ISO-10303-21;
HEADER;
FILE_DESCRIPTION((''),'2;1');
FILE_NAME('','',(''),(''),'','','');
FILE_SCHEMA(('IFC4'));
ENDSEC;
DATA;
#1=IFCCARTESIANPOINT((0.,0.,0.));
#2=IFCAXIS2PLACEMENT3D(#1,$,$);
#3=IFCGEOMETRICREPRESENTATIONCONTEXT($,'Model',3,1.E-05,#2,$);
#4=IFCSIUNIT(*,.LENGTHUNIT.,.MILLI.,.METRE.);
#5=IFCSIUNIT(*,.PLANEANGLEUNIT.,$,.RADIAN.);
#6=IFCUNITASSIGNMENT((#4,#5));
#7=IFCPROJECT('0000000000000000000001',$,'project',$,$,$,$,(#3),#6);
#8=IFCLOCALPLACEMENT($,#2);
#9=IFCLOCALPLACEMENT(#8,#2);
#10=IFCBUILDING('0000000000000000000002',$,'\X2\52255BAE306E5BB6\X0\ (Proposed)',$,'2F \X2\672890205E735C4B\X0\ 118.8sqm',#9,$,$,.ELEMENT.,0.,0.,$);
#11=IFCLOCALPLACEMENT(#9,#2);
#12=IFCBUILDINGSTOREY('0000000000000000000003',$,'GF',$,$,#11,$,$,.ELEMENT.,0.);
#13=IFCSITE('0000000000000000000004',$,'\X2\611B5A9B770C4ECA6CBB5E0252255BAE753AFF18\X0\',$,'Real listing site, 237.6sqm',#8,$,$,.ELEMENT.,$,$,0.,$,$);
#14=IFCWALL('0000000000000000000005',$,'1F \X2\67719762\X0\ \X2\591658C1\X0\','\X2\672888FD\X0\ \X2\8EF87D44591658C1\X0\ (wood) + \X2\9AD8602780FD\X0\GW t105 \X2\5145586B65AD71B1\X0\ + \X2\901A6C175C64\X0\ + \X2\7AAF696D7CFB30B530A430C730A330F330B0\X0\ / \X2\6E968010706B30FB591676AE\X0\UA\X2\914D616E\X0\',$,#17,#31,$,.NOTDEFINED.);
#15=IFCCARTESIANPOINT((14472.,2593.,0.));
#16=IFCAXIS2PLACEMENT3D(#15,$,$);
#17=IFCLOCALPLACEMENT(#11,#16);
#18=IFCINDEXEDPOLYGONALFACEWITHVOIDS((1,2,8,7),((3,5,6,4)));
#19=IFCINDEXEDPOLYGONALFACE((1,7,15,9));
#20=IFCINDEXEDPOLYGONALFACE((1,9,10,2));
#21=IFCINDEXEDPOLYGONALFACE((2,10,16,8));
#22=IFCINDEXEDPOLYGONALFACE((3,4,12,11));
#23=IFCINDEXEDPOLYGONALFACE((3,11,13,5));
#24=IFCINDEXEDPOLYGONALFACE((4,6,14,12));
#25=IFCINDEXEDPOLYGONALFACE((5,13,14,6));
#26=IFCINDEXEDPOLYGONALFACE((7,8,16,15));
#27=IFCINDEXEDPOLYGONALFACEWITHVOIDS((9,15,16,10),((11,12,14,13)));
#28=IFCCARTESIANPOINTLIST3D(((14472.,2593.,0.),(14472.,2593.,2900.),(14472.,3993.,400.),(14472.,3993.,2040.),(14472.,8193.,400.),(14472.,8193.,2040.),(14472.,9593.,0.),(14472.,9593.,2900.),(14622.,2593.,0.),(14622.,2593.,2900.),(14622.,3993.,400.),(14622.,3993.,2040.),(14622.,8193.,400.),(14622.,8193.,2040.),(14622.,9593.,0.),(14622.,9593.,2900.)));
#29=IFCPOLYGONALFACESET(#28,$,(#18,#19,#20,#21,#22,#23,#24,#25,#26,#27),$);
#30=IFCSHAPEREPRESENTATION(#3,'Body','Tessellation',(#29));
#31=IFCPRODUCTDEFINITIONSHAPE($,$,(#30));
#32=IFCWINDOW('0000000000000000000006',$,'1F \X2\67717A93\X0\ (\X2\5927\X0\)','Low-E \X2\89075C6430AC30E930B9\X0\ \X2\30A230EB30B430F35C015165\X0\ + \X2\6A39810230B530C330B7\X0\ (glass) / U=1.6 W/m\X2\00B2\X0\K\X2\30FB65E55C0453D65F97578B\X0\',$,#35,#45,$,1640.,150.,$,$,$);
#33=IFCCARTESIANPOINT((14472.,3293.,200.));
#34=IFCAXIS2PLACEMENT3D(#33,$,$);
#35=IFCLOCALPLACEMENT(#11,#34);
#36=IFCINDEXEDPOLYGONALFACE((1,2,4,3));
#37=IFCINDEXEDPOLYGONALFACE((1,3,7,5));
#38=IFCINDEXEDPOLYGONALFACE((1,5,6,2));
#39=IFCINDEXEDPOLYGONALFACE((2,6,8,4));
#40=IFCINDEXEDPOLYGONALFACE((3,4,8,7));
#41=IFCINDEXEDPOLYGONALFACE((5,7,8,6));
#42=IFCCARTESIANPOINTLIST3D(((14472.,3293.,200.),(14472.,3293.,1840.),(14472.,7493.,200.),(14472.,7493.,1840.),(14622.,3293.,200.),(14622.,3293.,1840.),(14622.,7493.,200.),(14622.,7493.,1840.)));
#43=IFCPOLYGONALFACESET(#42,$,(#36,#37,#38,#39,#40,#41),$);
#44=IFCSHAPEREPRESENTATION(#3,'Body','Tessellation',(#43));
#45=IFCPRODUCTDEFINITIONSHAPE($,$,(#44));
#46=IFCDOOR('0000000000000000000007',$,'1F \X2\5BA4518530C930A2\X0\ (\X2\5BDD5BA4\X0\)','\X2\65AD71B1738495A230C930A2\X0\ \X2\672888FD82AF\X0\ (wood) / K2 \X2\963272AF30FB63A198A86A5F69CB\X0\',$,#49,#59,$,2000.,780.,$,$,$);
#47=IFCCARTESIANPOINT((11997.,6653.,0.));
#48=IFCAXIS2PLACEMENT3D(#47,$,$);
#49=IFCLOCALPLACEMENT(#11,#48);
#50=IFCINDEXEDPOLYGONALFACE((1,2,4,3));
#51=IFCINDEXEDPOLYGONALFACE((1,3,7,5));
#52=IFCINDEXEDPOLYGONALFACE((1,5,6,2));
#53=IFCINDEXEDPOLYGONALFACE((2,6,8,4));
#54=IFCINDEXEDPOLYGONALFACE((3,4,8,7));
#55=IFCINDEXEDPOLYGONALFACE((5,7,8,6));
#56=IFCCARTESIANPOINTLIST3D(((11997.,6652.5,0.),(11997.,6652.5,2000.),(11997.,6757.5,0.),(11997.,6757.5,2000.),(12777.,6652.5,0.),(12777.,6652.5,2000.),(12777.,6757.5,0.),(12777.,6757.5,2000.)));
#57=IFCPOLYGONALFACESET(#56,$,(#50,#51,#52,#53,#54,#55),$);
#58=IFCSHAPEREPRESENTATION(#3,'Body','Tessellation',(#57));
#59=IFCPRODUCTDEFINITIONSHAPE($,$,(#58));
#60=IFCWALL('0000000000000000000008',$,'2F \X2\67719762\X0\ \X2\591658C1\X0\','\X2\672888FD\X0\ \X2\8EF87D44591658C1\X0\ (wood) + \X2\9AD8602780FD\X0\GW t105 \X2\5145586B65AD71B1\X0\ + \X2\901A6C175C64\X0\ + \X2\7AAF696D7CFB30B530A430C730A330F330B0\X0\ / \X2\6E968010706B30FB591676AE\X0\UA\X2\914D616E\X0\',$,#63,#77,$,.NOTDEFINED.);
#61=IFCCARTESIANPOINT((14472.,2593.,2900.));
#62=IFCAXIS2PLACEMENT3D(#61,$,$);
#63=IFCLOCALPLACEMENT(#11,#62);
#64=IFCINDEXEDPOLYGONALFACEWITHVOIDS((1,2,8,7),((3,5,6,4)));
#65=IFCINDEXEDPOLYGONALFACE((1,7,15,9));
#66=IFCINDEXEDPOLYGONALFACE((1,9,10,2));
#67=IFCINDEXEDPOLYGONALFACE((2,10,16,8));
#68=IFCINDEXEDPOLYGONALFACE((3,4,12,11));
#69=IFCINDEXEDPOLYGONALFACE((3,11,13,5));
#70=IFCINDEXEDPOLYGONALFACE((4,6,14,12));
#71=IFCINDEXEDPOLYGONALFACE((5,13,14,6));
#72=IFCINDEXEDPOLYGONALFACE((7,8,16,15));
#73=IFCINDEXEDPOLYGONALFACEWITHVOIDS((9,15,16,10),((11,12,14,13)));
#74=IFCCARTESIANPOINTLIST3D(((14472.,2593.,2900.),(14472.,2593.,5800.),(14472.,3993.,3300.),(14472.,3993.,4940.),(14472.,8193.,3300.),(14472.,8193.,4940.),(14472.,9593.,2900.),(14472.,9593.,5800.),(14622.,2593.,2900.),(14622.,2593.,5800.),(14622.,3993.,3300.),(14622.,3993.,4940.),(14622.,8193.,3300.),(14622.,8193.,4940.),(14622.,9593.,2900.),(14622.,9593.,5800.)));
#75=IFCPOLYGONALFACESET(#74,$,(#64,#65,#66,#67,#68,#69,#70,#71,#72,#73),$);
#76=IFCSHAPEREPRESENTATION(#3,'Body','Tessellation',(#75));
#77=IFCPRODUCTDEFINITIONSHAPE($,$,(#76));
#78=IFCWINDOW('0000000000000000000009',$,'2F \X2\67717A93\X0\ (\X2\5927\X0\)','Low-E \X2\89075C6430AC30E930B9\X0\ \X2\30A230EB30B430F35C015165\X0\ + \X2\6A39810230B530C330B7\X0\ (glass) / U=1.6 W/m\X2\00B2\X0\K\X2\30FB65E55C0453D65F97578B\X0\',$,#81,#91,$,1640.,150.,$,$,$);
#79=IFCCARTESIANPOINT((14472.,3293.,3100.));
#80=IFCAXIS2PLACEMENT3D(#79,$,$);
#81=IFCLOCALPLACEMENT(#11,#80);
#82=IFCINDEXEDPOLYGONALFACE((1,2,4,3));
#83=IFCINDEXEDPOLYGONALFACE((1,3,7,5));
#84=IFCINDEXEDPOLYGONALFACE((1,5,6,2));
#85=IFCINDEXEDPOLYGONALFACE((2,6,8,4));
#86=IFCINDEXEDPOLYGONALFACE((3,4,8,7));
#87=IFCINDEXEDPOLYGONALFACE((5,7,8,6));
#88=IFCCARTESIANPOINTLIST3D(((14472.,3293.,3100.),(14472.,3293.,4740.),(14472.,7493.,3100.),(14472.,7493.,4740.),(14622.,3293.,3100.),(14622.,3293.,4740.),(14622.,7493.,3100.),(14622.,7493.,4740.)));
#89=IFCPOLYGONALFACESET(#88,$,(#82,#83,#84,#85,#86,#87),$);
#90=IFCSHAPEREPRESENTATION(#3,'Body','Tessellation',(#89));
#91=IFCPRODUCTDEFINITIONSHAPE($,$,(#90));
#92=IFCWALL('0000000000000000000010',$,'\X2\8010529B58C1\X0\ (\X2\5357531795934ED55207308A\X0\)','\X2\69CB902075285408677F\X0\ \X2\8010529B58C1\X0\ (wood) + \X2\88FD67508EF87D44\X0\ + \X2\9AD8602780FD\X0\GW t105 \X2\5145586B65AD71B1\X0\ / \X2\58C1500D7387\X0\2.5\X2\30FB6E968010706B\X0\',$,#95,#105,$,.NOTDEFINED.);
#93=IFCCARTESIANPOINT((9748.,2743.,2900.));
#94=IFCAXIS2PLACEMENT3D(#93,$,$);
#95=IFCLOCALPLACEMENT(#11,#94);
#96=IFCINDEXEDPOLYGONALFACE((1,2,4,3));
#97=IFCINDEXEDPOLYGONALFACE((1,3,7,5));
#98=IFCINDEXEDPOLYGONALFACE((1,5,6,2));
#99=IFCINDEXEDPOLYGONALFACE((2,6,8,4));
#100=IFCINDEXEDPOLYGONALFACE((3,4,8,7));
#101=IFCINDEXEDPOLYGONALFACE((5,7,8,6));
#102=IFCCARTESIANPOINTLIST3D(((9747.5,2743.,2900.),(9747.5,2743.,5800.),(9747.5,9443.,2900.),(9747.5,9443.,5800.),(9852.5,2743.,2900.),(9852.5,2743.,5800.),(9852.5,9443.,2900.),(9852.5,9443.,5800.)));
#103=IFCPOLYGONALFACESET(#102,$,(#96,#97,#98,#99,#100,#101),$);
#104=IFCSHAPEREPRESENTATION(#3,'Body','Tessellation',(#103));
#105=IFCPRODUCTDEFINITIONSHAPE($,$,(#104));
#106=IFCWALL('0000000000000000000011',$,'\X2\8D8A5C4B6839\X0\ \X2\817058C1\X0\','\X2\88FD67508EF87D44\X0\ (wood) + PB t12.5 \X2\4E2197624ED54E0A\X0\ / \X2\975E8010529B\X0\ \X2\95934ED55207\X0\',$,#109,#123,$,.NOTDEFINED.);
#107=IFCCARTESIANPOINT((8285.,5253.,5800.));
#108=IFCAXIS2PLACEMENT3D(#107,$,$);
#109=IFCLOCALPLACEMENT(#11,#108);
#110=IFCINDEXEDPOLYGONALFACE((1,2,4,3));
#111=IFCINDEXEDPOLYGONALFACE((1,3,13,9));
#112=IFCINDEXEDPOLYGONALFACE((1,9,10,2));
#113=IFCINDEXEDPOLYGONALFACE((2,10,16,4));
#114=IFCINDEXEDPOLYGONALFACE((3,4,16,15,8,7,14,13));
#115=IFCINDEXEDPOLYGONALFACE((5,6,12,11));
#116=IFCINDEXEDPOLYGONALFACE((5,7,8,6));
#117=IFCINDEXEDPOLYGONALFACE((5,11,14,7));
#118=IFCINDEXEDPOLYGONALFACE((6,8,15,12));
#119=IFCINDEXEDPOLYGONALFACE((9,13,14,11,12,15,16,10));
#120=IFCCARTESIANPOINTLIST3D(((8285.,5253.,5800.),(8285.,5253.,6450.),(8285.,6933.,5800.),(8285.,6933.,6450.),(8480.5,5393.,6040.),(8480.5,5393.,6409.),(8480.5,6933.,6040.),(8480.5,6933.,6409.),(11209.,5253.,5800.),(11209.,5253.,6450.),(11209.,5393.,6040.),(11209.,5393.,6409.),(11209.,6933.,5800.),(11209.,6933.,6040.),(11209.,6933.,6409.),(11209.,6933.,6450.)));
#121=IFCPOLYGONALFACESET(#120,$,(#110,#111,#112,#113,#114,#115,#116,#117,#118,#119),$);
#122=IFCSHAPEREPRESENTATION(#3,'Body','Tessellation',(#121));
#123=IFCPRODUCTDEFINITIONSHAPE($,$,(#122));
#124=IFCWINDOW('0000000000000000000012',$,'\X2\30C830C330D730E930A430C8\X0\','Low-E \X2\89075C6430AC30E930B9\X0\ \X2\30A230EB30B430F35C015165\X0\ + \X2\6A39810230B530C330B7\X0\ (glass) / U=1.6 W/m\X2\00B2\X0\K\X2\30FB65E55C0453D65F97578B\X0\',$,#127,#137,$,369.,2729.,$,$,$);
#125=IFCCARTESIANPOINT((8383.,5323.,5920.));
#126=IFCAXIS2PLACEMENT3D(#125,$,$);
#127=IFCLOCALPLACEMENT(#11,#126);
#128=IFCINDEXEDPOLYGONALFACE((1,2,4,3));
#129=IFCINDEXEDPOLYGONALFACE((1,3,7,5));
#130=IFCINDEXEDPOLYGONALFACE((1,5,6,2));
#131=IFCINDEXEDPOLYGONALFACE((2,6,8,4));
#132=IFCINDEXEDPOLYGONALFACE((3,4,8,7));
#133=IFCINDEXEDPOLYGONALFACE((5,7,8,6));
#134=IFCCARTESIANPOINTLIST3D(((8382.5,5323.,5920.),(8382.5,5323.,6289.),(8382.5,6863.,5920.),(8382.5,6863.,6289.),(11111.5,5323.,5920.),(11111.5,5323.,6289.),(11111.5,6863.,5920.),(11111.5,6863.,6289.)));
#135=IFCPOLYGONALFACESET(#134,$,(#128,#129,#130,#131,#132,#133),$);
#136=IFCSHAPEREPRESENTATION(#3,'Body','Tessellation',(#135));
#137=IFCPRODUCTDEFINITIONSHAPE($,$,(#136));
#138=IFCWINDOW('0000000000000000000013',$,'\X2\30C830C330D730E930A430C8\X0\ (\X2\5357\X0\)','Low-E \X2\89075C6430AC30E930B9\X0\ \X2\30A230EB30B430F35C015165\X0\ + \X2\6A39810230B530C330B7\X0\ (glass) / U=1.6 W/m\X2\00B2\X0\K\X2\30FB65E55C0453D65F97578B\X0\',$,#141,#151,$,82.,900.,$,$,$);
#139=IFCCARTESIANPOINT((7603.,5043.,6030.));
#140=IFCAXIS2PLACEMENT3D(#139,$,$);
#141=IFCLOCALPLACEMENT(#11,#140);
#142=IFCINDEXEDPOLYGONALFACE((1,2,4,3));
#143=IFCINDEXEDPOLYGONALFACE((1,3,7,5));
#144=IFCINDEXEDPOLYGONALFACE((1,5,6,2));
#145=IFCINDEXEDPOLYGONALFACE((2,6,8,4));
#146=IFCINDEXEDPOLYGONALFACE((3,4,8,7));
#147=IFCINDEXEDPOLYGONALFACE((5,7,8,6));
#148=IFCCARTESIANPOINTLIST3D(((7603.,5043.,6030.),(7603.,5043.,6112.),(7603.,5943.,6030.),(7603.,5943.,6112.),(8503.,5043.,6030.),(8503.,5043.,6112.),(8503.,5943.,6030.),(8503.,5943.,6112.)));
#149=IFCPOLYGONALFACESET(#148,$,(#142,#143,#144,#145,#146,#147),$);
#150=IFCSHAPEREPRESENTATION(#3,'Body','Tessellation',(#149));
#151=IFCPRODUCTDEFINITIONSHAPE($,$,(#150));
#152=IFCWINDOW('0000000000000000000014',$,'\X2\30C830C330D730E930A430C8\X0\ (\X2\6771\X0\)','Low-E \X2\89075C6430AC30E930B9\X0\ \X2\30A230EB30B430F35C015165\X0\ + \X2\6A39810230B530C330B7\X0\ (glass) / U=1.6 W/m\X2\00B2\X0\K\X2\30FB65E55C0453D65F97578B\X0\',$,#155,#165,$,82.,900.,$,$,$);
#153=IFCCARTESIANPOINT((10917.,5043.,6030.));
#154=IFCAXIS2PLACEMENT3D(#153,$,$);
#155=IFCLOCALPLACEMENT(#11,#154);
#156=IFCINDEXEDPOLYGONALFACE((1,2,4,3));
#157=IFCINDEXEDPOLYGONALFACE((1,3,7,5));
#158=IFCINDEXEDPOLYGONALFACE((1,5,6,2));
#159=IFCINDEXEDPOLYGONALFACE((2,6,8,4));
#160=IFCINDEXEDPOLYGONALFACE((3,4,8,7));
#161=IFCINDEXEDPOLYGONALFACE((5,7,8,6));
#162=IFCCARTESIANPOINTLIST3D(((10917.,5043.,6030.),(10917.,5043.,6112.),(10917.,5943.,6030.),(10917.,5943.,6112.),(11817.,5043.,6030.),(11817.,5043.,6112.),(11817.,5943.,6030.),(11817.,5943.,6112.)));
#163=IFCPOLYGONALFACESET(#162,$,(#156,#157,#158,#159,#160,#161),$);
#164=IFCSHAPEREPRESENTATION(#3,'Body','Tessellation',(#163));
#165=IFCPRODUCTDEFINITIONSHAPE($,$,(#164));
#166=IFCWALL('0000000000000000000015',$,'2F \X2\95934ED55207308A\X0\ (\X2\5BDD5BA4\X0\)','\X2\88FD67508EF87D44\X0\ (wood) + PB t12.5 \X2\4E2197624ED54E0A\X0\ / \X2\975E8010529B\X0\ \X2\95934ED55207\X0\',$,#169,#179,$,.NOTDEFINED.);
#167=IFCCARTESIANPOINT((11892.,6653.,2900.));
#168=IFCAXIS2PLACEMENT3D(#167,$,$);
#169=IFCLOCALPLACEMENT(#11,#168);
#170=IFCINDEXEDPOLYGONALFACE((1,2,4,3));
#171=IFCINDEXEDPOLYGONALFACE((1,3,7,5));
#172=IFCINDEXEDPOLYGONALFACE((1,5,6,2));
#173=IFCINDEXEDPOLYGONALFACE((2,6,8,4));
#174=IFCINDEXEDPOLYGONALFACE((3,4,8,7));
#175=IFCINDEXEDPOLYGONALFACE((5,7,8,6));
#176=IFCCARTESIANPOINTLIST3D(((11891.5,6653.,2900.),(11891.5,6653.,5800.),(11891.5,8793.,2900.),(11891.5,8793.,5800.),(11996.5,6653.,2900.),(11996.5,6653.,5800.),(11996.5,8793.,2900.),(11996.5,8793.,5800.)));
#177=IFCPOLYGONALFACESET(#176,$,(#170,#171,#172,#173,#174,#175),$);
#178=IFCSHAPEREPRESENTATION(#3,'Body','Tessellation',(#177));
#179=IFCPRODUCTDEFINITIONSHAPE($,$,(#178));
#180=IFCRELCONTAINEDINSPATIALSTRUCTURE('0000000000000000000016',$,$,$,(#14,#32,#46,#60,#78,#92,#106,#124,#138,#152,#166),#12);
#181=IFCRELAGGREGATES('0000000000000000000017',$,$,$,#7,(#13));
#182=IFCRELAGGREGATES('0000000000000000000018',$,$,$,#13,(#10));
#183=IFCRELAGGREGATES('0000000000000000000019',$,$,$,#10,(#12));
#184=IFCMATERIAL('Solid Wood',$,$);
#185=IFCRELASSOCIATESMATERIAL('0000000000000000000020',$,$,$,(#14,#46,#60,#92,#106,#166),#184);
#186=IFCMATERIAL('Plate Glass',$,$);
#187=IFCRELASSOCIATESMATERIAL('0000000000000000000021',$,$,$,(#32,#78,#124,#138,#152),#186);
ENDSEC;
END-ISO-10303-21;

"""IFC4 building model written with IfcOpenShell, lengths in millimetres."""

from ifc_helpers import new_model, si_unit, frame, frame_2d, origin, place, context, project, spatial, rectangle, extrude, material, element, fill, save


model = new_model("IFC4")

# Units and contexts
model_context = context("Model", 3, precision=1e-05, world=origin())
ifc_project = project(units=[si_unit("LENGTHUNIT", "METRE", prefix="MILLI"), si_unit("PLANEANGLEUNIT", "RADIAN")], contexts=[model_context])

# Site, building, storey
site_placement = place(None, origin())
site = spatial("IfcSite", under=ifc_project, at=site_placement, Name="愛媛県今治市別宮町８", ObjectType="Real listing site, 237.6sqm", CompositionType="ELEMENT", RefElevation=0.0)
building_placement = place(site_placement, origin())
building = spatial("IfcBuilding", under=site, at=building_placement, Name="別宮の家 (Proposed)", ObjectType="2F 木造平屋 118.8sqm", CompositionType="ELEMENT", ElevationOfRefHeight=0.0, ElevationOfTerrain=0.0)
storey_placement = place(building_placement, origin())
storey = spatial("IfcBuildingStorey", under=building, at=storey_placement, Name="GF", CompositionType="ELEMENT", Elevation=0.0)

# Wall, opening, window
ifc_material_1 = material(Name="Solid Wood")
wall_1_placement = place(storey_placement, frame((14472.0, 2593.0, 0.0)))
wall_1 = element("IfcWall", 1, at=wall_1_placement, inside=storey, material=ifc_material_1, Name="1F 東面 外壁", Description="木製 軸組外壁 (wood) + 高性能GW t105 充填断熱 + 通気層 + 窯業系サイディング / 準耐火・外皮UA配慮", PredefinedType="NOTDEFINED", context=model_context, shape_type="SweptSolid", body=[
    extrude(rectangle(XDim=150.0, YDim=7000.0, at=frame_2d((75.0, 3500.0))), frame((14472.0, 2593.0, 0.0)), (0.0, 0.0, 1.0), 2900.0),
])
opening_1_placement = place(storey_placement, frame((14472.0, 3293.0, 200.0)))
opening_1 = element("IfcOpeningElement", 2, at=opening_1_placement, cuts=wall_1, PredefinedType="NOTDEFINED", context=model_context, shape_type="SweptSolid", body=[
    extrude(rectangle(XDim=150.0, YDim=4200.0, at=frame_2d((75.0, 2100.0))), frame((14472.0, 3293.0, 200.0)), (0.0, 0.0, 1.0), 1640.0),
])
ifc_material_2 = material(Name="Plate Glass")
window_1_placement = place(storey_placement, frame((14472.0, 3293.0, 200.0)))
window_1 = element("IfcWindow", 3, at=window_1_placement, inside=storey, material=ifc_material_2, Name="1F 東窓 (大)", Description="Low-E 複層ガラス アルゴン封入 + 樹脂サッシ (glass) / U=1.6 W/m²K・日射取得型", OverallHeight=1640.0, OverallWidth=150.0, context=model_context, shape_type="SweptSolid", body=[
    extrude(rectangle(XDim=150.0, YDim=4200.0, at=frame_2d((75.0, 2100.0))), frame((14472.0, 3293.0, 200.0)), (0.0, 0.0, 1.0), 1640.0),
])
fill(opening_1, window_1)

# Door
door_1_placement = place(storey_placement, frame((11997.0, 6653.0, 0.0)))
element("IfcDoor", 4, at=door_1_placement, inside=storey, material=ifc_material_1, Name="1F 室内ドア (寝室)", Description="断熱玄関ドア 木製芯 (wood) / K2 防犯・採風機構", OverallHeight=2000.0, OverallWidth=780.0, context=model_context, shape_type="SweptSolid", body=[
    extrude(rectangle(XDim=780.0, YDim=105.0, at=frame_2d((390.0, 52.0))), frame((11997.0, 6653.0, 0.0)), (0.0, 0.0, 1.0), 2000.0),
])

# Wall, opening, window
wall_2_placement = place(storey_placement, frame((14472.0, 2593.0, 2900.0)))
wall_2 = element("IfcWall", 5, at=wall_2_placement, inside=storey, material=ifc_material_1, Name="2F 東面 外壁", Description="木製 軸組外壁 (wood) + 高性能GW t105 充填断熱 + 通気層 + 窯業系サイディング / 準耐火・外皮UA配慮", PredefinedType="NOTDEFINED", context=model_context, shape_type="SweptSolid", body=[
    extrude(rectangle(XDim=150.0, YDim=7000.0, at=frame_2d((75.0, 3500.0))), frame((14472.0, 2593.0, 2900.0)), (0.0, 0.0, 1.0), 2900.0),
])
opening_2_placement = place(storey_placement, frame((14472.0, 3293.0, 3100.0)))
opening_2 = element("IfcOpeningElement", 6, at=opening_2_placement, cuts=wall_2, PredefinedType="NOTDEFINED", context=model_context, shape_type="SweptSolid", body=[
    extrude(rectangle(XDim=150.0, YDim=4200.0, at=frame_2d((75.0, 2100.0))), frame((14472.0, 3293.0, 3100.0)), (0.0, 0.0, 1.0), 1640.0),
])
window_2_placement = place(storey_placement, frame((14472.0, 3293.0, 3100.0)))
window_2 = element("IfcWindow", 7, at=window_2_placement, inside=storey, material=ifc_material_2, Name="2F 東窓 (大)", Description="Low-E 複層ガラス アルゴン封入 + 樹脂サッシ (glass) / U=1.6 W/m²K・日射取得型", OverallHeight=1640.0, OverallWidth=150.0, context=model_context, shape_type="SweptSolid", body=[
    extrude(rectangle(XDim=150.0, YDim=4200.0, at=frame_2d((75.0, 2100.0))), frame((14472.0, 3293.0, 3100.0)), (0.0, 0.0, 1.0), 1640.0),
])
fill(opening_2, window_2)

# Wall
wall_3_placement = place(storey_placement, frame((9748.0, 2743.0, 2900.0)))
element("IfcWall", 8, at=wall_3_placement, inside=storey, material=ifc_material_1, Name="耐力壁 (南北間仕切り)", Description="構造用合板 耐力壁 (wood) + 製材軸組 + 高性能GW t105 充填断熱 / 壁倍率2.5・準耐火", PredefinedType="NOTDEFINED", context=model_context, shape_type="SweptSolid", body=[
    extrude(rectangle(XDim=105.0, YDim=6700.0, at=frame_2d((52.0, 3350.0))), frame((9748.0, 2743.0, 2900.0)), (0.0, 0.0, 1.0), 2900.0),
])

# Wall, openings, windows
wall_4_placement = place(storey_placement, frame((8285.0, 5253.0, 5800.0)))
wall_4 = element("IfcWall", 9, at=wall_4_placement, inside=storey, material=ifc_material_1, Name="越屋根 腰壁", Description="製材軸組 (wood) + PB t12.5 両面仕上 / 非耐力 間仕切", PredefinedType="NOTDEFINED", context=model_context, shape_type="SweptSolid", body=[
    extrude(rectangle(XDim=2924.0, YDim=1680.0, at=frame_2d((1462.0, 840.0))), frame((8285.0, 5253.0, 5800.0)), (0.0, 0.0, 1.0), 650.0),
])
opening_3_placement = place(storey_placement, frame((8383.0, 5323.0, 5920.0)))
opening_3 = element("IfcOpeningElement", 10, at=opening_3_placement, cuts=wall_4, PredefinedType="NOTDEFINED", context=model_context, shape_type="SweptSolid", body=[
    extrude(rectangle(XDim=2729.0, YDim=1540.0, at=frame_2d((1364.0, 770.0))), frame((8383.0, 5323.0, 5920.0)), (0.0, 0.0, 1.0), 369.0),
])
opening_4_placement = place(storey_placement, frame((7603.0, 5043.0, 6030.0)))
opening_4 = element("IfcOpeningElement", 11, at=opening_4_placement, cuts=wall_4, PredefinedType="NOTDEFINED", context=model_context, shape_type="SweptSolid", body=[
    extrude(rectangle(XDim=900.0, YDim=900.0, at=frame_2d((450.0, 450.0))), frame((7603.0, 5043.0, 6030.0)), (0.0, 0.0, 1.0), 82.0),
])
opening_5_placement = place(storey_placement, frame((10917.0, 5043.0, 6030.0)))
opening_5 = element("IfcOpeningElement", 12, at=opening_5_placement, cuts=wall_4, PredefinedType="NOTDEFINED", context=model_context, shape_type="SweptSolid", body=[
    extrude(rectangle(XDim=900.0, YDim=900.0, at=frame_2d((450.0, 450.0))), frame((10917.0, 5043.0, 6030.0)), (0.0, 0.0, 1.0), 82.0),
])
window_3_placement = place(storey_placement, frame((8383.0, 5323.0, 5920.0)))
window_3 = element("IfcWindow", 13, at=window_3_placement, inside=storey, material=ifc_material_2, Name="トップライト", Description="Low-E 複層ガラス アルゴン封入 + 樹脂サッシ (glass) / U=1.6 W/m²K・日射取得型", OverallHeight=369.0, OverallWidth=2729.0, context=model_context, shape_type="SweptSolid", body=[
    extrude(rectangle(XDim=2729.0, YDim=1540.0, at=frame_2d((1364.0, 770.0))), frame((8383.0, 5323.0, 5920.0)), (0.0, 0.0, 1.0), 369.0),
])
fill(opening_3, window_3)
window_4_placement = place(storey_placement, frame((7603.0, 5043.0, 6030.0)))
window_4 = element("IfcWindow", 14, at=window_4_placement, inside=storey, material=ifc_material_2, Name="トップライト (南)", Description="Low-E 複層ガラス アルゴン封入 + 樹脂サッシ (glass) / U=1.6 W/m²K・日射取得型", OverallHeight=82.0, OverallWidth=900.0, context=model_context, shape_type="SweptSolid", body=[
    extrude(rectangle(XDim=900.0, YDim=900.0, at=frame_2d((450.0, 450.0))), frame((7603.0, 5043.0, 6030.0)), (0.0, 0.0, 1.0), 82.0),
])
fill(opening_4, window_4)
window_5_placement = place(storey_placement, frame((10917.0, 5043.0, 6030.0)))
window_5 = element("IfcWindow", 15, at=window_5_placement, inside=storey, material=ifc_material_2, Name="トップライト (東)", Description="Low-E 複層ガラス アルゴン封入 + 樹脂サッシ (glass) / U=1.6 W/m²K・日射取得型", OverallHeight=82.0, OverallWidth=900.0, context=model_context, shape_type="SweptSolid", body=[
    extrude(rectangle(XDim=900.0, YDim=900.0, at=frame_2d((450.0, 450.0))), frame((10917.0, 5043.0, 6030.0)), (0.0, 0.0, 1.0), 82.0),
])
fill(opening_5, window_5)

# Wall
wall_5_placement = place(storey_placement, frame((11892.0, 6653.0, 2900.0)))
element("IfcWall", 16, at=wall_5_placement, inside=storey, material=ifc_material_1, Name="2F 間仕切り (寝室)", Description="製材軸組 (wood) + PB t12.5 両面仕上 / 非耐力 間仕切", PredefinedType="NOTDEFINED", context=model_context, shape_type="SweptSolid", body=[
    extrude(rectangle(XDim=105.0, YDim=2140.0, at=frame_2d((52.0, 1070.0))), frame((11892.0, 6653.0, 2900.0)), (0.0, 0.0, 1.0), 2900.0),
])

save(model, "model.ifc")
